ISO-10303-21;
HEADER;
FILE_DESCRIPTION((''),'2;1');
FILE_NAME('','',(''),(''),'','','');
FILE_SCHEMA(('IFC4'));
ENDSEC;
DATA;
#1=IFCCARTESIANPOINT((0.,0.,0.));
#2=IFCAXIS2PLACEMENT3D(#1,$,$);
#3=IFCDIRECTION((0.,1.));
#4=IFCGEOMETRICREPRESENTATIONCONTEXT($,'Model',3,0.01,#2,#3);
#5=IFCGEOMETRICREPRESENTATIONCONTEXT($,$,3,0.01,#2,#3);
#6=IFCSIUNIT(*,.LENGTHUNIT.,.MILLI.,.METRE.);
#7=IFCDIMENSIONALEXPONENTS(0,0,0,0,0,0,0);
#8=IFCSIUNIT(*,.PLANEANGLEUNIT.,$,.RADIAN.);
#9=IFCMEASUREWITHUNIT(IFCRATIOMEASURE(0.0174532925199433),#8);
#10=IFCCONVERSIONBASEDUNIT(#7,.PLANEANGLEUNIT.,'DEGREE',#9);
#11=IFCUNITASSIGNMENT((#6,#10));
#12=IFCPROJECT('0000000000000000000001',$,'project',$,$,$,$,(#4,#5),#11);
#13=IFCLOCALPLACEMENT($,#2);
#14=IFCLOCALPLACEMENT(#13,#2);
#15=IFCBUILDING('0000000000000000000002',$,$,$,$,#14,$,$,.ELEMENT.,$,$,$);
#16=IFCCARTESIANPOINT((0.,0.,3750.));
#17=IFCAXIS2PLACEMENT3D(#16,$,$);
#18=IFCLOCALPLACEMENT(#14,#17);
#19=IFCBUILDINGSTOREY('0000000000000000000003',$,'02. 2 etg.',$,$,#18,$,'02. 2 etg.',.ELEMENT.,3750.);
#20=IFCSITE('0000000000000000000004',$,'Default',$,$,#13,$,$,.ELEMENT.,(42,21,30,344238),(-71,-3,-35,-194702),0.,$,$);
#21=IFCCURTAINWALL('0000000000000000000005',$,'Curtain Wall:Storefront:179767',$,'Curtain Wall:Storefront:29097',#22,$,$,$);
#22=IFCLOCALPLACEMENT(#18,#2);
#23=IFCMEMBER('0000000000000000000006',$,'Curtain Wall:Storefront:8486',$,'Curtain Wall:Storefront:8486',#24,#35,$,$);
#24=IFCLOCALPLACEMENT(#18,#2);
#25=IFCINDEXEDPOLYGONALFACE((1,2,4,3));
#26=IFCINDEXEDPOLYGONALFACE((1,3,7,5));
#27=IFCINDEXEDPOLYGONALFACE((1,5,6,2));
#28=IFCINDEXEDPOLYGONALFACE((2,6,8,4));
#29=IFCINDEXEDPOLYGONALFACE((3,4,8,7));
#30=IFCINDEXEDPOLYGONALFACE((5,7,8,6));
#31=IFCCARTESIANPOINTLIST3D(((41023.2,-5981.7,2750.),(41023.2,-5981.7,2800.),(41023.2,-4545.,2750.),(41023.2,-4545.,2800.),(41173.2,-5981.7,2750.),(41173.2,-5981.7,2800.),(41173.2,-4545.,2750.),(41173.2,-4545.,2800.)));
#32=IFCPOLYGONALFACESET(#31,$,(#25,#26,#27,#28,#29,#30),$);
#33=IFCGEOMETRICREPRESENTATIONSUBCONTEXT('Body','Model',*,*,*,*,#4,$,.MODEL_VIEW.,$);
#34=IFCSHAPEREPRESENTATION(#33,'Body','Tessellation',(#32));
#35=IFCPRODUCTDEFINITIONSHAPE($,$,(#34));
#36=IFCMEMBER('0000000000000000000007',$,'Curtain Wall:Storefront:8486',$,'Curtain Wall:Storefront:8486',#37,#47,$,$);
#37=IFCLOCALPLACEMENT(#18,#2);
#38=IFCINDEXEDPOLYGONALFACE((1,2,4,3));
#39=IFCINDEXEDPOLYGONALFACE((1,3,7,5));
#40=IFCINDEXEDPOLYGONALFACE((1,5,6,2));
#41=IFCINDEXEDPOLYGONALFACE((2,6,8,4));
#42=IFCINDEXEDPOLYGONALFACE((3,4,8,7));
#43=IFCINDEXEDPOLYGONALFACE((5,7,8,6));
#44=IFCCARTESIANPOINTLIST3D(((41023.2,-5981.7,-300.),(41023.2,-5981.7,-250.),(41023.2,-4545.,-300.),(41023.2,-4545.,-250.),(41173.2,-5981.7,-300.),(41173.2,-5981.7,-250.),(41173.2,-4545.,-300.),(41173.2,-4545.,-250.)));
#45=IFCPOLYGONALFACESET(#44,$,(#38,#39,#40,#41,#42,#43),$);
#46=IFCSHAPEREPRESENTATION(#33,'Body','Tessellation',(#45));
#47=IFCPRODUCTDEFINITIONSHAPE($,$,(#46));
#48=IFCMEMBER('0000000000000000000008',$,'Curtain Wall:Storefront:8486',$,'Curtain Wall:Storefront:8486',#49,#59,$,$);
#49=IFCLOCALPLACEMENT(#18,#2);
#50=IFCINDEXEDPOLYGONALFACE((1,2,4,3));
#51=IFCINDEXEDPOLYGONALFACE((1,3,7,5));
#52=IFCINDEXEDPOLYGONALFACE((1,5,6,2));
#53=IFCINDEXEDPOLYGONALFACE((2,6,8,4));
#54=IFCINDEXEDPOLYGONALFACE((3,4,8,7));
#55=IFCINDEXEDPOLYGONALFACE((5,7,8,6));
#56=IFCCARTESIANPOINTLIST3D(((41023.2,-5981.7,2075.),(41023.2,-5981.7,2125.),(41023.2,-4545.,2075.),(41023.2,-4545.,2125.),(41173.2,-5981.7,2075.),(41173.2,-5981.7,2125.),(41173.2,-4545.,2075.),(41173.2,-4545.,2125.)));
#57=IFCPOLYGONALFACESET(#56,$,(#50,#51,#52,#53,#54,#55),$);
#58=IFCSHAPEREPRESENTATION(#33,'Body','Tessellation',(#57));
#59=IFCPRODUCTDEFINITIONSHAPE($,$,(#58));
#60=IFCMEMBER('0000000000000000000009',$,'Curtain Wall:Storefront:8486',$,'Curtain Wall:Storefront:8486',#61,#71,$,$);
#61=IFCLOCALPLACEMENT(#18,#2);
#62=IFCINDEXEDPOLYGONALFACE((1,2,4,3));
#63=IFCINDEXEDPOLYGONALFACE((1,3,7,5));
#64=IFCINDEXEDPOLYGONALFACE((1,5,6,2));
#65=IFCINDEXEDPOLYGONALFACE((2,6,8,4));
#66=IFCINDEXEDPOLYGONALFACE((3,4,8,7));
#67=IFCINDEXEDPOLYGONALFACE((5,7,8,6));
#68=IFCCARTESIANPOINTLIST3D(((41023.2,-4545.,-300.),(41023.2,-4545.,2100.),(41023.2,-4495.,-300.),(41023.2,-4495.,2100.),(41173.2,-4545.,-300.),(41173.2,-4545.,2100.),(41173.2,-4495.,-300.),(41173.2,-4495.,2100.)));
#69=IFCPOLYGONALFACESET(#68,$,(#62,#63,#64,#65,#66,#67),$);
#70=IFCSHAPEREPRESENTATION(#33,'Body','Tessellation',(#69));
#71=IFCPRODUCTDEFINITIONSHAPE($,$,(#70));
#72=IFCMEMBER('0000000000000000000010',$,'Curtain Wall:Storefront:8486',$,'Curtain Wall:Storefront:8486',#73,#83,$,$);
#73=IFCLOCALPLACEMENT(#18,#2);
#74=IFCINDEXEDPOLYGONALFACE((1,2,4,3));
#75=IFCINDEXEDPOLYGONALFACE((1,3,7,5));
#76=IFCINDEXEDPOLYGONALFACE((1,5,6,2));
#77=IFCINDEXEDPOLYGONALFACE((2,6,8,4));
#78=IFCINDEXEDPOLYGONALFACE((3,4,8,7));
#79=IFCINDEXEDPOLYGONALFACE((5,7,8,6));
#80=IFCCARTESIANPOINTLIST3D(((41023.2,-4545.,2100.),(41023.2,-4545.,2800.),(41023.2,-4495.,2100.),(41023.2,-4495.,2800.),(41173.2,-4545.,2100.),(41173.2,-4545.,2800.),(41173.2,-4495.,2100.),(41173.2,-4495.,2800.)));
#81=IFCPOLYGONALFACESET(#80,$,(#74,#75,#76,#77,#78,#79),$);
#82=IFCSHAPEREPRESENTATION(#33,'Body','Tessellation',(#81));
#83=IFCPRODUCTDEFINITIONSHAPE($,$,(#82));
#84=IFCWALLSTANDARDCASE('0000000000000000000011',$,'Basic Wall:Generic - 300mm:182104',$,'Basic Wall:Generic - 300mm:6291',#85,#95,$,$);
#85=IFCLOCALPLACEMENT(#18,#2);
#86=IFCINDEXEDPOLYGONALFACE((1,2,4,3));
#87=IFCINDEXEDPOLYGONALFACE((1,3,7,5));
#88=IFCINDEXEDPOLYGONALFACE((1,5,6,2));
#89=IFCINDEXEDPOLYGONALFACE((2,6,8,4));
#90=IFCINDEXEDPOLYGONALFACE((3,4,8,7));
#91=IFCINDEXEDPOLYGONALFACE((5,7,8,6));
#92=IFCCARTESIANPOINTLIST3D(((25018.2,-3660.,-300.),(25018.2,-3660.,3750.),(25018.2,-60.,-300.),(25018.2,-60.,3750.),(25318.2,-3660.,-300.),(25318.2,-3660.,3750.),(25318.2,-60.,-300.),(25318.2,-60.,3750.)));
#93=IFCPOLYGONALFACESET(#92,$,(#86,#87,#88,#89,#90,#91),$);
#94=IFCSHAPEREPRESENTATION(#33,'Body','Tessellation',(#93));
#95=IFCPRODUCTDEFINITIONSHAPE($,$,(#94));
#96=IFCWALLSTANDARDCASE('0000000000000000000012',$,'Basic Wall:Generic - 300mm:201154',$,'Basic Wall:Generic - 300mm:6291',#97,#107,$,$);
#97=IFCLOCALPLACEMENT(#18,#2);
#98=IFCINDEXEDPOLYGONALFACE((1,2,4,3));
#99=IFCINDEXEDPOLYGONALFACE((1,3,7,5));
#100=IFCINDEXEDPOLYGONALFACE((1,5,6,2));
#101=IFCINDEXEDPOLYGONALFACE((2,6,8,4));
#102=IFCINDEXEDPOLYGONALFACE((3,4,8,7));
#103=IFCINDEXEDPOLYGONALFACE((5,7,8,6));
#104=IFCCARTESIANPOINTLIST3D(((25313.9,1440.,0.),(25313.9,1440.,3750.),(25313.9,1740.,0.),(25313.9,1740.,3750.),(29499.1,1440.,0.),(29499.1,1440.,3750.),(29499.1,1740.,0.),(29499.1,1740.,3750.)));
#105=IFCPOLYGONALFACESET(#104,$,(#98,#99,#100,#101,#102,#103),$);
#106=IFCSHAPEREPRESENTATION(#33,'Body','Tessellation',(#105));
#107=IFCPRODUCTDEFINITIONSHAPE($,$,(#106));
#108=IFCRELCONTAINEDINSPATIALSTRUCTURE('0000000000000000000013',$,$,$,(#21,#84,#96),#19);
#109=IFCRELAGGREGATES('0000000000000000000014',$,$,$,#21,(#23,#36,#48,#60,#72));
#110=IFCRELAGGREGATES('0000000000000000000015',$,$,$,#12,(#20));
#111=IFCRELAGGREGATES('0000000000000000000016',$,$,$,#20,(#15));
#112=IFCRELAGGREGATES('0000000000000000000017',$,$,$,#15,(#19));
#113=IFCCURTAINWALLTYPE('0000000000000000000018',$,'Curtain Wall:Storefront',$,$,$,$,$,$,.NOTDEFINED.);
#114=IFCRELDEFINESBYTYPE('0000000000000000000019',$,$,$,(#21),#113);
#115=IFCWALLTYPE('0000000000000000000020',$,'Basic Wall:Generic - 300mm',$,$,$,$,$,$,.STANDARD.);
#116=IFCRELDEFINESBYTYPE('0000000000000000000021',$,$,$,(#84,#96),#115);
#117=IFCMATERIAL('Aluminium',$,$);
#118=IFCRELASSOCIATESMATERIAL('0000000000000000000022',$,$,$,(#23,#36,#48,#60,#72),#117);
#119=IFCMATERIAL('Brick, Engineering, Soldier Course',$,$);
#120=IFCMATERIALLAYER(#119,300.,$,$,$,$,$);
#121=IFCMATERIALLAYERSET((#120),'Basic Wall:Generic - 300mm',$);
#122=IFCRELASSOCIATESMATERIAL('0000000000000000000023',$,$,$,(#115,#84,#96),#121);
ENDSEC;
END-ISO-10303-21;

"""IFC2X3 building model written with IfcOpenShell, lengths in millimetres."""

from ifc_helpers import new_model, entity, si_unit, converted_unit, direction, frame, frame_2d, origin, origin_2d_with_axis, place, context, subcontext, project, spatial, rectangle, extrude, material, layer, layer_set, layer_usage, type_object, element, aggregate, save


model = new_model("IFC2X3")

# Units and contexts
model_context = context("Model", 3, precision=0.01, world=origin(), true_north=direction((0.0, 1.0)))
context_of_model = context(None, 3, precision=0.01, world=origin(), true_north=direction((0.0, 1.0)))
body_context = subcontext(model_context, "Body", "Model", "MODEL_VIEW")
ifc_project = project(units=[si_unit("LENGTHUNIT", "METRE", prefix="MILLI"), converted_unit("PLANEANGLEUNIT", "DEGREE", entity("IfcRatioMeasure", 0.0174532925199433), si_unit("PLANEANGLEUNIT", "RADIAN"), dimensions=[0, 0, 0, 0, 0, 0, 0])], contexts=[model_context, context_of_model])

# Site, building, storey
site_placement = place(None, origin())
site = spatial("IfcSite", under=ifc_project, at=site_placement, Name="Default", CompositionType="ELEMENT", RefLatitude=(42, 21, 30, 344238), RefLongitude=(-71, -3, -35, -194702), RefElevation=0.0)
building_placement = place(site_placement, origin())
building = spatial("IfcBuilding", under=site, at=building_placement, CompositionType="ELEMENT")
storey_placement = place(building_placement, frame((0.0, 0.0, 3750.0)))
storey = spatial("IfcBuildingStorey", under=building, at=storey_placement, Name="02. 2 etg.", LongName="02. 2 etg.", CompositionType="ELEMENT", Elevation=3750.0)

# Curtain wall, members
curtain_wall_type = type_object("IfcCurtainWallType", Name="Curtain Wall:Storefront", PredefinedType="NOTDEFINED")
curtain_wall_placement = place(storey_placement, frame((0.0, 0.0, -3750.0)))
curtain_wall = element("IfcCurtainWall", 1, at=curtain_wall_placement, inside=storey, type_object=curtain_wall_type, Name="Curtain Wall:Storefront:179767", ObjectType="Curtain Wall:Storefront:29097")
ifc_material_1 = material(Name="Aluminium")
member_1_placement = place(curtain_wall_placement, frame((41023.2, -5981.7, 6500.0)))
member_1 = element("IfcMember", 2, at=member_1_placement, material=ifc_material_1, Name="Curtain Wall:Storefront:8486", ObjectType="Curtain Wall:Storefront:8486", context=body_context, shape_type="SweptSolid", body=[
    extrude(rectangle(XDim=1436.7, YDim=150.0, at=frame_2d((0.0, 0.0), x_axis=(1.0, 0.0))), frame((75.0, 718.3, 0.0), z_axis=(0.0, 0.0, 1.0), x_axis=(0.0, 1.0, 0.0)), (0.0, 0.0, 1.0), 50.0),
])
member_2_placement = place(curtain_wall_placement, frame((41023.2, -5981.7, 3450.0)))
member_2 = element("IfcMember", 3, at=member_2_placement, material=ifc_material_1, Name="Curtain Wall:Storefront:8486", ObjectType="Curtain Wall:Storefront:8486", context=body_context, shape_type="SweptSolid", body=[
    extrude(rectangle(XDim=1436.7, YDim=150.0, at=origin_2d_with_axis()), frame((75.0, 718.3, 0.0), z_axis=(0.0, 0.0, 1.0), x_axis=(0.0, -1.0, 0.0)), (0.0, 0.0, 1.0), 50.0),
])
member_3_placement = place(curtain_wall_placement, frame((41023.2, -5981.7, 5825.0)))
member_3 = element("IfcMember", 4, at=member_3_placement, material=ifc_material_1, Name="Curtain Wall:Storefront:8486", ObjectType="Curtain Wall:Storefront:8486", context=body_context, shape_type="SweptSolid", body=[
    extrude(rectangle(XDim=1436.7, YDim=150.0, at=frame_2d((0.0, 0.0), x_axis=(1.0, 0.0))), frame((75.0, 718.3, 0.0), z_axis=(0.0, 0.0, 1.0), x_axis=(0.0, 1.0, 0.0)), (0.0, 0.0, 1.0), 50.0),
])
member_4_placement = place(curtain_wall_placement, frame((41023.2, -4545.0, 3450.0)))
member_4 = element("IfcMember", 5, at=member_4_placement, material=ifc_material_1, Name="Curtain Wall:Storefront:8486", ObjectType="Curtain Wall:Storefront:8486", context=body_context, shape_type="SweptSolid", body=[
    extrude(rectangle(XDim=150.0, YDim=50.0, at=frame_2d((0.0, 0.0), x_axis=(1.0, 0.0))), frame((75.0, 25.0, 0.0)), (0.0, 0.0, 1.0), 2400.0),
])
member_5_placement = place(curtain_wall_placement, frame((41023.2, -4545.0, 5850.0)))
member_5 = element("IfcMember", 6, at=member_5_placement, material=ifc_material_1, Name="Curtain Wall:Storefront:8486", ObjectType="Curtain Wall:Storefront:8486", context=body_context, shape_type="SweptSolid", body=[
    extrude(rectangle(XDim=150.0, YDim=50.0, at=origin_2d_with_axis()), frame((75.0, 25.0, 0.0)), (0.0, 0.0, 1.0), 700.0),
])
aggregate(curtain_wall, [member_1, member_2, member_3, member_4, member_5])

# Walls
ifc_material_2 = material(Name="Brick, Engineering, Soldier Course")
ifc_layer_1 = layer(ifc_material_2, 300.0)
ifc_layer_set_1 = layer_set([ifc_layer_1], Name="Basic Wall:Generic - 300mm")
ifc_layer_usage_1 = layer_usage(ifc_layer_set_1, "AXIS2", "NEGATIVE", 150.0)
wall_type_1 = type_object("IfcWallType", Name="Basic Wall:Generic - 300mm", PredefinedType="STANDARD", material=ifc_layer_set_1)
wall_1_placement = place(storey_placement, frame((25168.2, -3660.0, -300.0), z_axis=(0.0, 0.0, 1.0), x_axis=(0.0, 1.0, 0.0)))
element("IfcWallStandardCase", 7, at=wall_1_placement, inside=storey, type_object=wall_type_1, material=ifc_layer_usage_1, Name="Basic Wall:Generic - 300mm:182104", ObjectType="Basic Wall:Generic - 300mm:6291", context=body_context, shape_type="SweptSolid", body=[
    extrude(rectangle(XDim=3600.0, YDim=300.0, at=frame_2d((1800.0, 0.0), x_axis=(-1.0, 0.0))), origin(), (0.0, 0.0, 1.0), 4050.0),
])
ifc_layer_usage_2 = layer_usage(ifc_layer_set_1, "AXIS2", "NEGATIVE", 150.0)
wall_2_placement = place(storey_placement, frame((29499.1, 1590.0, 0.0), z_axis=(0.0, 0.0, 1.0), x_axis=(-1.0, 0.0, 0.0)))
element("IfcWallStandardCase", 8, at=wall_2_placement, inside=storey, type_object=wall_type_1, material=ifc_layer_usage_2, Name="Basic Wall:Generic - 300mm:201154", ObjectType="Basic Wall:Generic - 300mm:6291", context=body_context, shape_type="SweptSolid", body=[
    extrude(rectangle(XDim=4185.2, YDim=300.0, at=frame_2d((2092.6, 0.0), x_axis=(-1.0, 0.0))), origin(), (0.0, 0.0, 1.0), 3750.0),
])

save(model, "model.ifc")
